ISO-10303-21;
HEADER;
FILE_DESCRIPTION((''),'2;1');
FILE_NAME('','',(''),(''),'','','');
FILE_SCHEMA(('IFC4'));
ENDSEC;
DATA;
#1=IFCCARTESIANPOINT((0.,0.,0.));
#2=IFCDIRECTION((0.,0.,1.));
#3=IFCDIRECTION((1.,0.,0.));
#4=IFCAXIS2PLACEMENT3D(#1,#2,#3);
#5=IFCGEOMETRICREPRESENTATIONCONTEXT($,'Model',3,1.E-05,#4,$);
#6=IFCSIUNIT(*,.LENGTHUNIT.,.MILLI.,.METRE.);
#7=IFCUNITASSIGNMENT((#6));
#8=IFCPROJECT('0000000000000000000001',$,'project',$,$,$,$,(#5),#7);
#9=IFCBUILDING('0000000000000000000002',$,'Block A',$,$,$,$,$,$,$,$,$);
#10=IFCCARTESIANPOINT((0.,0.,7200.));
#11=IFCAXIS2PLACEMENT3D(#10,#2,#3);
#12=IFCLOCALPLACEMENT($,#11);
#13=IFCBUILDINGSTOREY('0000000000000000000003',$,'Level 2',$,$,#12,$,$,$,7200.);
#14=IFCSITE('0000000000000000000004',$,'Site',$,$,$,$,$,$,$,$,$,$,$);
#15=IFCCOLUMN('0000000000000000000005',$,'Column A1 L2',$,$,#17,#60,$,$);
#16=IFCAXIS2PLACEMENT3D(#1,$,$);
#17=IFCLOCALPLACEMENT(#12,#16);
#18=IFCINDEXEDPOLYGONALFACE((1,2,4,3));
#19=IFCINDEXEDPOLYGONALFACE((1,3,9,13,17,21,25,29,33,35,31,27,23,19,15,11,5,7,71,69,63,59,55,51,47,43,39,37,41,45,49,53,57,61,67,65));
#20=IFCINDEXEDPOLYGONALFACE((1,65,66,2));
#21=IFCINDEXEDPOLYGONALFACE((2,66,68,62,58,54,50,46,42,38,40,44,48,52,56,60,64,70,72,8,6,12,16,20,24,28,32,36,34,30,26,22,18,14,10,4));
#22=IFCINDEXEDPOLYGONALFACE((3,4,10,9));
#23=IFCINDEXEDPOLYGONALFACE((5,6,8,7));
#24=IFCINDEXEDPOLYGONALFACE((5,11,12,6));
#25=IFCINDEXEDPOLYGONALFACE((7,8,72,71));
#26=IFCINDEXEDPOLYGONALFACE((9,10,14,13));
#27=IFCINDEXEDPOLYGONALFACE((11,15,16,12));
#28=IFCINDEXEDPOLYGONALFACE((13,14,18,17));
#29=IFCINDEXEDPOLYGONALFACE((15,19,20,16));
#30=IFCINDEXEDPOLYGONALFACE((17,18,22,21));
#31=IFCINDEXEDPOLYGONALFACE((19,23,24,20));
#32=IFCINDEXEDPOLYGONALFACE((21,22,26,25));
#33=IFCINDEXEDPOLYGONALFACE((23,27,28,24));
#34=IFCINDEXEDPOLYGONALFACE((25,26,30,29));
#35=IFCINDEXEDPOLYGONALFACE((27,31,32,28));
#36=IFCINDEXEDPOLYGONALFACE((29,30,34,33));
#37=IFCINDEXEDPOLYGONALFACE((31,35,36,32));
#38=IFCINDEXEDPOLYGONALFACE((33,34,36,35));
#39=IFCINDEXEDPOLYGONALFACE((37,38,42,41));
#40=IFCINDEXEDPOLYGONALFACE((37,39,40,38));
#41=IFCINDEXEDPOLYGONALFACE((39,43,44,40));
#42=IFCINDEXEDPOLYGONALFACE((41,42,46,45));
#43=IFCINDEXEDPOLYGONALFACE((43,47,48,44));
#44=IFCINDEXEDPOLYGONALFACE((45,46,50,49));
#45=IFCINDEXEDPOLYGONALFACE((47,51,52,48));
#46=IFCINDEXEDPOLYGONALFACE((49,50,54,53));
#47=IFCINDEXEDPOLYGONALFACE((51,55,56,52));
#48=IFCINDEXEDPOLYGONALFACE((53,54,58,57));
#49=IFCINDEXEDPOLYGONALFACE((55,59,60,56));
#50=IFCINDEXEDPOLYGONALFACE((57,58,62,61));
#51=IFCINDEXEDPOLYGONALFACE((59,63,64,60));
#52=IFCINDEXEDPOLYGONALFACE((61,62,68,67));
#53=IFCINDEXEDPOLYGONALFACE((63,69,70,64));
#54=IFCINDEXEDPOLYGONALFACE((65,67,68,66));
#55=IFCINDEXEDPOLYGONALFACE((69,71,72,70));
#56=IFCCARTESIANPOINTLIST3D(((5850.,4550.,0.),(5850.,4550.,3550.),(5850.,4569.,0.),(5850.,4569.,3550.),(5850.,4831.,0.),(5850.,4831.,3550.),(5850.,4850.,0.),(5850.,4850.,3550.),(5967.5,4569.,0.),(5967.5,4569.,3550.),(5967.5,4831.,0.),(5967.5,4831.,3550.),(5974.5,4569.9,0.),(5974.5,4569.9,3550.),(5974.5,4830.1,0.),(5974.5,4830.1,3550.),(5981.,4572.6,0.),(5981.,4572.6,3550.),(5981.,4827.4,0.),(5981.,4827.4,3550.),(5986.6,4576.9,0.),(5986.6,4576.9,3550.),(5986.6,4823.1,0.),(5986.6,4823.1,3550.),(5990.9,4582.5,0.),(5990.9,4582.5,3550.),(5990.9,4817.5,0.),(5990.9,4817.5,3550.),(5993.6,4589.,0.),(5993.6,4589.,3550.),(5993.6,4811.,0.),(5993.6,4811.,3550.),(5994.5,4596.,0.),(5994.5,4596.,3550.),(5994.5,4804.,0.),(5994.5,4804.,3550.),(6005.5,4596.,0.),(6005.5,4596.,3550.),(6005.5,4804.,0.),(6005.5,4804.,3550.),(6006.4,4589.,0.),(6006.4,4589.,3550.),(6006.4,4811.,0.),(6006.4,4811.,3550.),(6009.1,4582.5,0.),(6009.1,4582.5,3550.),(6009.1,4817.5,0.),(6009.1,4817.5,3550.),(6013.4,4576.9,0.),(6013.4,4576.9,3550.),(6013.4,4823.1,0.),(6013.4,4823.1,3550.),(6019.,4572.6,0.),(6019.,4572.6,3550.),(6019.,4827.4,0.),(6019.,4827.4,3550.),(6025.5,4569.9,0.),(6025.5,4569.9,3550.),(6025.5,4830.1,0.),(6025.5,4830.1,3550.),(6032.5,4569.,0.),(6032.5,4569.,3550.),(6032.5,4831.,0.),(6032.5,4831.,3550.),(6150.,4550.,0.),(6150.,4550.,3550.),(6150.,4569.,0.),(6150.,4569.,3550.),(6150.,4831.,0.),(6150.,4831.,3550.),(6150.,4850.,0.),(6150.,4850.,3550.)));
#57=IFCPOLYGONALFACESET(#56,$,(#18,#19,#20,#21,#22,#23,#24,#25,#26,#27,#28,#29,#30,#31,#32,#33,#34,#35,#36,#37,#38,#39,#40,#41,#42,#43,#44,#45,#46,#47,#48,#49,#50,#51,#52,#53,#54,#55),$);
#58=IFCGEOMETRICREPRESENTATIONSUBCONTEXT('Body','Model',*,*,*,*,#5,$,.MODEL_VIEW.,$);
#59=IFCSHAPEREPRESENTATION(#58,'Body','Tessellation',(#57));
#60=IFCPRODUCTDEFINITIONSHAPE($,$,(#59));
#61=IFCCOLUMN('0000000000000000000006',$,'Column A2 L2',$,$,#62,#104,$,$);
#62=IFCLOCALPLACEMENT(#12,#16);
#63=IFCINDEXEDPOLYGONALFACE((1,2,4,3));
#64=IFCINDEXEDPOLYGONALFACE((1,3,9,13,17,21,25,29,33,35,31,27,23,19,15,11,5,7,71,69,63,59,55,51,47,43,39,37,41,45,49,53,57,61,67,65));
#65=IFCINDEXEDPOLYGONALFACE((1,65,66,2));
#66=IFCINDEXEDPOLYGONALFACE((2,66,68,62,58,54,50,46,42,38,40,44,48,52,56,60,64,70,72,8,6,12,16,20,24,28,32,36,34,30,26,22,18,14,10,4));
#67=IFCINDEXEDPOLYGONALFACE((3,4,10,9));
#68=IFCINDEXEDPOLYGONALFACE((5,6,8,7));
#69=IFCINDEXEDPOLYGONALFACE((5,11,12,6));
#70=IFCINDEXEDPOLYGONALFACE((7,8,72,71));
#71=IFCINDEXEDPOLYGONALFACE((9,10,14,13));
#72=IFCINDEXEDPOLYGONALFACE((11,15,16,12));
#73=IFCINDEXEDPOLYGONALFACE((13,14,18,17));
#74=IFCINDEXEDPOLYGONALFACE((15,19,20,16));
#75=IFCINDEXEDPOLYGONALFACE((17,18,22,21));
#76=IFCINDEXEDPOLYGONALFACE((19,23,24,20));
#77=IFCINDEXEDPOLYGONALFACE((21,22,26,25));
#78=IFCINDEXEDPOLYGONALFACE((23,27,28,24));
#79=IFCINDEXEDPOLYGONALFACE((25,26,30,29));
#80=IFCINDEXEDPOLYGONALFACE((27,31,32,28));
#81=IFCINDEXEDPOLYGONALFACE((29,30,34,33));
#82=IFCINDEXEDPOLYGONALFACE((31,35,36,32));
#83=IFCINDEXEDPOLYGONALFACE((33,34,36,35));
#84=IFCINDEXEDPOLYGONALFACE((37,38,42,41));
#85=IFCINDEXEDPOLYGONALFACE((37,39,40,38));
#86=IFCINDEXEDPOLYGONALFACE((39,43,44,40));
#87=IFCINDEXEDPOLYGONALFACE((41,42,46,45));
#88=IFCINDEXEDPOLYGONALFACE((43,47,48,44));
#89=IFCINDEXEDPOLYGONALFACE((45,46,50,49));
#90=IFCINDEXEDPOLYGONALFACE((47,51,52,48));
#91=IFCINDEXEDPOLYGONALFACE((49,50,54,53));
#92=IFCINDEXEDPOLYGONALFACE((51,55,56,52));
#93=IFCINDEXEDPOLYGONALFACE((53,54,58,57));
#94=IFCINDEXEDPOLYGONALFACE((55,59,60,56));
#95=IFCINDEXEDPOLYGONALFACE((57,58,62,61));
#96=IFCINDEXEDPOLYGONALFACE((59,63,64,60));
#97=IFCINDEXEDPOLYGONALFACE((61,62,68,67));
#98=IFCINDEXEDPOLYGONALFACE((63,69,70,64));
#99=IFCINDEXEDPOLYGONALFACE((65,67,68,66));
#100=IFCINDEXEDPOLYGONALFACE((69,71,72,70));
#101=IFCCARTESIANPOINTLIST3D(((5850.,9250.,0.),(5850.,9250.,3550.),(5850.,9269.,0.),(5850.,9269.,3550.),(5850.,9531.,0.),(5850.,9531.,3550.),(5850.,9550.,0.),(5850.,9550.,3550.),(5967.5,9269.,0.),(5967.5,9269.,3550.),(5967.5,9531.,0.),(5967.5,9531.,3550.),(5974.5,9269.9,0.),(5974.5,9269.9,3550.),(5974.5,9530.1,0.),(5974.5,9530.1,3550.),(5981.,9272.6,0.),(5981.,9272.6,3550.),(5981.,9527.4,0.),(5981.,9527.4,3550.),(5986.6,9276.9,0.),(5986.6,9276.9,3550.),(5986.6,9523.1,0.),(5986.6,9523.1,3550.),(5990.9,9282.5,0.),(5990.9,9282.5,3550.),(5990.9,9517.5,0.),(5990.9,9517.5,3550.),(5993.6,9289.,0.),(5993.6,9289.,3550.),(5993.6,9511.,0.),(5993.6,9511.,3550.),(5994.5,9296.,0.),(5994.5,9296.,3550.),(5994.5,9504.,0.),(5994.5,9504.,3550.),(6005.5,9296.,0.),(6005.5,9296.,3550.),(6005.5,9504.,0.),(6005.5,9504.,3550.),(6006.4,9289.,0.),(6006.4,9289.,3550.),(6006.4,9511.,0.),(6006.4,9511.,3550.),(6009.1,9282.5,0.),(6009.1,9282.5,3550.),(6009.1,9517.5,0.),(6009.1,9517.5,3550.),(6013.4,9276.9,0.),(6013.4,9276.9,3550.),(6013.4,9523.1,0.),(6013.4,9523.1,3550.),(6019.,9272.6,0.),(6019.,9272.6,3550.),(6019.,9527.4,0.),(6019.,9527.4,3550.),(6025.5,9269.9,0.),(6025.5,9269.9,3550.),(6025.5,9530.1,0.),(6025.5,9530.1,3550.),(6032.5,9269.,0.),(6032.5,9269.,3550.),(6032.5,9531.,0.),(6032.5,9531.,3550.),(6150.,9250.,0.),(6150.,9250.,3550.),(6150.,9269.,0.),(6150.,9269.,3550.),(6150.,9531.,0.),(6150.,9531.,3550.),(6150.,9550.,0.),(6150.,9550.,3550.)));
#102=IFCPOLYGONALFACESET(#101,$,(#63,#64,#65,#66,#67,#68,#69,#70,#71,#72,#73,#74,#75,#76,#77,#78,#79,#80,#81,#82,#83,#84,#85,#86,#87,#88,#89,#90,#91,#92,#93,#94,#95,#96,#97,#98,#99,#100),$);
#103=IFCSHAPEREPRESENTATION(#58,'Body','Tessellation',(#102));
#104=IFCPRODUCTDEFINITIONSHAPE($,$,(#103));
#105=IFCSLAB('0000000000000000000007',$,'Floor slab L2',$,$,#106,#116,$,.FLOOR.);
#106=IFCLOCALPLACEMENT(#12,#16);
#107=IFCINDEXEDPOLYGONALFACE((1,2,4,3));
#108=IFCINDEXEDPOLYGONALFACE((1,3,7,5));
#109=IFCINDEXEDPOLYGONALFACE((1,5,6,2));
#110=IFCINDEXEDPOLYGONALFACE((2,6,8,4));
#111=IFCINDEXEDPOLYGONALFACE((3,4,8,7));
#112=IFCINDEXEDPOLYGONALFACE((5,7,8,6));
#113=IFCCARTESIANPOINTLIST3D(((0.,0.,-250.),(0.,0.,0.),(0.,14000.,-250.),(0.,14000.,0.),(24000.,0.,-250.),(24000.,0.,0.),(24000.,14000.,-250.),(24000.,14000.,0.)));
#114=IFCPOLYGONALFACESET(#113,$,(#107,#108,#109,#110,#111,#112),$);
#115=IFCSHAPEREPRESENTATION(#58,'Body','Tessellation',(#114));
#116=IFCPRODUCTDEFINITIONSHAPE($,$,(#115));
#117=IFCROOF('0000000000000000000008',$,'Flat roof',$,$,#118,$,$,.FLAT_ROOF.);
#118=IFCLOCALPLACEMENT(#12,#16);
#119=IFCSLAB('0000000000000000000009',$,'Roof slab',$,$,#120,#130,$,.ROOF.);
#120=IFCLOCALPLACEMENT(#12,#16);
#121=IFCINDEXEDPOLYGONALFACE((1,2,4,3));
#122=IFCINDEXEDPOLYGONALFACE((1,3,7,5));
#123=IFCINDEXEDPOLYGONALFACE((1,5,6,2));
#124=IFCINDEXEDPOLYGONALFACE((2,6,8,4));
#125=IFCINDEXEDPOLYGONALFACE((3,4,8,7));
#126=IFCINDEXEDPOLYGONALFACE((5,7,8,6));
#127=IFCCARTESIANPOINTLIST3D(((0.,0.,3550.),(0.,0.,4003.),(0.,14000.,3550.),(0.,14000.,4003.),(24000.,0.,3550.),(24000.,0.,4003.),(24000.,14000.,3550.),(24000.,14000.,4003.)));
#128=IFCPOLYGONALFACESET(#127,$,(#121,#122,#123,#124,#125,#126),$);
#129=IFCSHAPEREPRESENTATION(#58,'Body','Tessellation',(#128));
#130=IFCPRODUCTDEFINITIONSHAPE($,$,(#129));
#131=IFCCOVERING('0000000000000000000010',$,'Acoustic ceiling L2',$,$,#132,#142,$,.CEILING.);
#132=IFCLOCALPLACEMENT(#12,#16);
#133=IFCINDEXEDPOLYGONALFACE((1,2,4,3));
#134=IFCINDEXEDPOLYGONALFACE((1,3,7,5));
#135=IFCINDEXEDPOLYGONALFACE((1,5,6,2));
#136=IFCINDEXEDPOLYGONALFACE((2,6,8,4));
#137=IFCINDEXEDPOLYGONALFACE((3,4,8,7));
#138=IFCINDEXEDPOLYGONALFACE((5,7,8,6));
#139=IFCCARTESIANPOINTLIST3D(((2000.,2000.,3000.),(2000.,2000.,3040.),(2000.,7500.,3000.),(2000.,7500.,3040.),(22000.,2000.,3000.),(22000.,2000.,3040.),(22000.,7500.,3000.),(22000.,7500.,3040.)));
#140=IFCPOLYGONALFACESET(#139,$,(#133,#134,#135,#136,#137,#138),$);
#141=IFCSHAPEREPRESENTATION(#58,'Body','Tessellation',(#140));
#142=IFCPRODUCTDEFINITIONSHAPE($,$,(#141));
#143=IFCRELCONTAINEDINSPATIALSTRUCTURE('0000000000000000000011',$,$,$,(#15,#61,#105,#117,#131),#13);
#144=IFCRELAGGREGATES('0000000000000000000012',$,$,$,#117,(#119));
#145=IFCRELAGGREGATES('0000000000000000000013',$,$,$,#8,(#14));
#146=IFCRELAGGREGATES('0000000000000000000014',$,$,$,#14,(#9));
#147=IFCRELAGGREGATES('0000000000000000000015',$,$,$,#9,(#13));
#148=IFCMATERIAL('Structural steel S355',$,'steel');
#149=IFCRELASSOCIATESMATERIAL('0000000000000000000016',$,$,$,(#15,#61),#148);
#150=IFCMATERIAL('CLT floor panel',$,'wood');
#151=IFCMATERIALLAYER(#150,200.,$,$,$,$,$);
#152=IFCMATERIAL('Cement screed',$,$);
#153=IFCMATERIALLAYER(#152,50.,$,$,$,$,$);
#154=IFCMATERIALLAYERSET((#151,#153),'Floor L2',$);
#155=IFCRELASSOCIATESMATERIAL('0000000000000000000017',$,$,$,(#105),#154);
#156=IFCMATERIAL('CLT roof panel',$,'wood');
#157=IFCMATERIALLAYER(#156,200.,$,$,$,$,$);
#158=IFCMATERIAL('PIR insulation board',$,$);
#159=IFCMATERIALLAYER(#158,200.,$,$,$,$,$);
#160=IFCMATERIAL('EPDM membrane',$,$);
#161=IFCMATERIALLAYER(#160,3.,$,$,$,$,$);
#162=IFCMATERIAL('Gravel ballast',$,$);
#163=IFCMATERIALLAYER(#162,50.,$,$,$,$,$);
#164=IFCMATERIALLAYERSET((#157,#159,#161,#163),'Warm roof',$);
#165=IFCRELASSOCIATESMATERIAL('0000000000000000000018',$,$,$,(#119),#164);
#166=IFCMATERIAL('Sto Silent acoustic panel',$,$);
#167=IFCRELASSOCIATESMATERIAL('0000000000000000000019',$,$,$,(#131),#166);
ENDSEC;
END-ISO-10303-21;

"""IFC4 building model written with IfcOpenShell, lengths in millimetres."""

from ifc_helpers import new_model, si_unit, frame, origin_with_axes, place, context, subcontext, project, spatial, indexed_curve, i_section, outline, extrude, material, layer, layer_set, layer_usage, material_profile, profile_set, element, aggregate, save


model = new_model("IFC4")

# Units and contexts
model_context = context("Model", 3, precision=1e-05, world=origin_with_axes())
body_context = subcontext(model_context, "Body", "Model", "MODEL_VIEW")
ifc_project = project(units=[si_unit("LENGTHUNIT", "METRE", prefix="MILLI")], contexts=[model_context])

# Site, building, storey
site = spatial("IfcSite", under=ifc_project, Name="Site")
building = spatial("IfcBuilding", under=site, Name="Block A")
storey_placement = place(None, frame((0.0, 0.0, 7200.0), z_axis=(0.0, 0.0, 1.0), x_axis=(1.0, 0.0, 0.0)))
storey = spatial("IfcBuildingStorey", under=building, at=storey_placement, Name="Level 2", Elevation=7200.0)

# Columns
ifc_material_1 = material(Name="Structural steel S355", Category="steel")
ifc_material_profile = material_profile(ifc_material_1, i_section(OverallWidth=300.0, OverallDepth=300.0, WebThickness=11.0, FlangeThickness=19.0, FilletRadius=27.0))
ifc_profile_set = profile_set([ifc_material_profile], Name="HEB 300")
for number, where, z_axis, x_axis, name in (
    (1, (6000.0, 4700.0, 0.0), (0.0, 0.0, 1.0), (1.0, 0.0, 0.0), "Column A1 L2"),
    (2, (6000.0, 9400.0, 0.0), (0.0, 0.0, 1.0), (1.0, 0.0, 0.0), "Column A2 L2"),
):
    element("IfcColumn", number, at=place(storey_placement, frame(where, z_axis=z_axis, x_axis=x_axis)), inside=storey, material=ifc_profile_set, Name=name, context=body_context, shape_type="SweptSolid", body=[
        extrude(i_section(OverallWidth=300.0, OverallDepth=300.0, WebThickness=11.0, FlangeThickness=19.0, FilletRadius=27.0), origin_with_axes(), (0.0, 0.0, 1.0), 3550.0),
    ])

# Slab
ifc_material_2 = material(Name="CLT floor panel", Category="wood")
ifc_layer_1 = layer(ifc_material_2, 200.0)
ifc_material_3 = material(Name="Cement screed")
ifc_layer_2 = layer(ifc_material_3, 50.0)
ifc_layer_set_1 = layer_set([ifc_layer_1, ifc_layer_2], Name="Floor L2")
ifc_layer_usage_1 = layer_usage(ifc_layer_set_1, "AXIS3", "POSITIVE", 0.0)
slab_1_placement = place(storey_placement, frame((0.0, 0.0, -250.0), z_axis=(0.0, 0.0, 1.0), x_axis=(1.0, 0.0, 0.0)))
element("IfcSlab", 3, at=slab_1_placement, inside=storey, material=ifc_layer_usage_1, Name="Floor slab L2", PredefinedType="FLOOR", context=body_context, shape_type="SweptSolid", body=[
    extrude(outline(indexed_curve([(0.0, 0.0), (24000.0, 0.0), (24000.0, 14000.0), (0.0, 14000.0), (0.0, 0.0)])), None, (0.0, 0.0, 1.0), 250.0),
])

# Roof, slab
roof_placement = place(storey_placement, frame((0.0, 0.0, 3550.0), z_axis=(0.0, 0.0, 1.0), x_axis=(1.0, 0.0, 0.0)))
roof = element("IfcRoof", 4, at=roof_placement, inside=storey, Name="Flat roof", PredefinedType="FLAT_ROOF")
ifc_material_4 = material(Name="CLT roof panel", Category="wood")
ifc_layer_3 = layer(ifc_material_4, 200.0)
ifc_material_5 = material(Name="PIR insulation board")
ifc_layer_4 = layer(ifc_material_5, 200.0)
ifc_material_6 = material(Name="EPDM membrane")
ifc_layer_5 = layer(ifc_material_6, 3.0)
ifc_material_7 = material(Name="Gravel ballast")
ifc_layer_6 = layer(ifc_material_7, 50.0)
ifc_layer_set_2 = layer_set([ifc_layer_3, ifc_layer_4, ifc_layer_5, ifc_layer_6], Name="Warm roof")
ifc_layer_usage_2 = layer_usage(ifc_layer_set_2, "AXIS3", "POSITIVE", 0.0)
slab_2_placement = place(roof_placement, origin_with_axes())
slab_2 = element("IfcSlab", 5, at=slab_2_placement, material=ifc_layer_usage_2, Name="Roof slab", PredefinedType="ROOF", context=body_context, shape_type="SweptSolid", body=[
    extrude(outline(indexed_curve([(0.0, 0.0), (24000.0, 0.0), (24000.0, 14000.0), (0.0, 14000.0), (0.0, 0.0)])), None, (0.0, 0.0, 1.0), 453.0),
])
aggregate(roof, [slab_2])

# Covering
ifc_material_8 = material(Name="Sto Silent acoustic panel")
covering_placement = place(storey_placement, frame((0.0, 0.0, 3000.0), z_axis=(0.0, 0.0, 1.0), x_axis=(1.0, 0.0, 0.0)))
element("IfcCovering", 6, at=covering_placement, inside=storey, material=ifc_material_8, Name="Acoustic ceiling L2", PredefinedType="CEILING", context=body_context, shape_type="SweptSolid", body=[
    extrude(outline(indexed_curve([(2000.0, 2000.0), (22000.0, 2000.0), (22000.0, 7500.0), (2000.0, 7500.0), (2000.0, 2000.0)])), None, (0.0, 0.0, 1.0), 40.0),
])

save(model, "model.ifc")
